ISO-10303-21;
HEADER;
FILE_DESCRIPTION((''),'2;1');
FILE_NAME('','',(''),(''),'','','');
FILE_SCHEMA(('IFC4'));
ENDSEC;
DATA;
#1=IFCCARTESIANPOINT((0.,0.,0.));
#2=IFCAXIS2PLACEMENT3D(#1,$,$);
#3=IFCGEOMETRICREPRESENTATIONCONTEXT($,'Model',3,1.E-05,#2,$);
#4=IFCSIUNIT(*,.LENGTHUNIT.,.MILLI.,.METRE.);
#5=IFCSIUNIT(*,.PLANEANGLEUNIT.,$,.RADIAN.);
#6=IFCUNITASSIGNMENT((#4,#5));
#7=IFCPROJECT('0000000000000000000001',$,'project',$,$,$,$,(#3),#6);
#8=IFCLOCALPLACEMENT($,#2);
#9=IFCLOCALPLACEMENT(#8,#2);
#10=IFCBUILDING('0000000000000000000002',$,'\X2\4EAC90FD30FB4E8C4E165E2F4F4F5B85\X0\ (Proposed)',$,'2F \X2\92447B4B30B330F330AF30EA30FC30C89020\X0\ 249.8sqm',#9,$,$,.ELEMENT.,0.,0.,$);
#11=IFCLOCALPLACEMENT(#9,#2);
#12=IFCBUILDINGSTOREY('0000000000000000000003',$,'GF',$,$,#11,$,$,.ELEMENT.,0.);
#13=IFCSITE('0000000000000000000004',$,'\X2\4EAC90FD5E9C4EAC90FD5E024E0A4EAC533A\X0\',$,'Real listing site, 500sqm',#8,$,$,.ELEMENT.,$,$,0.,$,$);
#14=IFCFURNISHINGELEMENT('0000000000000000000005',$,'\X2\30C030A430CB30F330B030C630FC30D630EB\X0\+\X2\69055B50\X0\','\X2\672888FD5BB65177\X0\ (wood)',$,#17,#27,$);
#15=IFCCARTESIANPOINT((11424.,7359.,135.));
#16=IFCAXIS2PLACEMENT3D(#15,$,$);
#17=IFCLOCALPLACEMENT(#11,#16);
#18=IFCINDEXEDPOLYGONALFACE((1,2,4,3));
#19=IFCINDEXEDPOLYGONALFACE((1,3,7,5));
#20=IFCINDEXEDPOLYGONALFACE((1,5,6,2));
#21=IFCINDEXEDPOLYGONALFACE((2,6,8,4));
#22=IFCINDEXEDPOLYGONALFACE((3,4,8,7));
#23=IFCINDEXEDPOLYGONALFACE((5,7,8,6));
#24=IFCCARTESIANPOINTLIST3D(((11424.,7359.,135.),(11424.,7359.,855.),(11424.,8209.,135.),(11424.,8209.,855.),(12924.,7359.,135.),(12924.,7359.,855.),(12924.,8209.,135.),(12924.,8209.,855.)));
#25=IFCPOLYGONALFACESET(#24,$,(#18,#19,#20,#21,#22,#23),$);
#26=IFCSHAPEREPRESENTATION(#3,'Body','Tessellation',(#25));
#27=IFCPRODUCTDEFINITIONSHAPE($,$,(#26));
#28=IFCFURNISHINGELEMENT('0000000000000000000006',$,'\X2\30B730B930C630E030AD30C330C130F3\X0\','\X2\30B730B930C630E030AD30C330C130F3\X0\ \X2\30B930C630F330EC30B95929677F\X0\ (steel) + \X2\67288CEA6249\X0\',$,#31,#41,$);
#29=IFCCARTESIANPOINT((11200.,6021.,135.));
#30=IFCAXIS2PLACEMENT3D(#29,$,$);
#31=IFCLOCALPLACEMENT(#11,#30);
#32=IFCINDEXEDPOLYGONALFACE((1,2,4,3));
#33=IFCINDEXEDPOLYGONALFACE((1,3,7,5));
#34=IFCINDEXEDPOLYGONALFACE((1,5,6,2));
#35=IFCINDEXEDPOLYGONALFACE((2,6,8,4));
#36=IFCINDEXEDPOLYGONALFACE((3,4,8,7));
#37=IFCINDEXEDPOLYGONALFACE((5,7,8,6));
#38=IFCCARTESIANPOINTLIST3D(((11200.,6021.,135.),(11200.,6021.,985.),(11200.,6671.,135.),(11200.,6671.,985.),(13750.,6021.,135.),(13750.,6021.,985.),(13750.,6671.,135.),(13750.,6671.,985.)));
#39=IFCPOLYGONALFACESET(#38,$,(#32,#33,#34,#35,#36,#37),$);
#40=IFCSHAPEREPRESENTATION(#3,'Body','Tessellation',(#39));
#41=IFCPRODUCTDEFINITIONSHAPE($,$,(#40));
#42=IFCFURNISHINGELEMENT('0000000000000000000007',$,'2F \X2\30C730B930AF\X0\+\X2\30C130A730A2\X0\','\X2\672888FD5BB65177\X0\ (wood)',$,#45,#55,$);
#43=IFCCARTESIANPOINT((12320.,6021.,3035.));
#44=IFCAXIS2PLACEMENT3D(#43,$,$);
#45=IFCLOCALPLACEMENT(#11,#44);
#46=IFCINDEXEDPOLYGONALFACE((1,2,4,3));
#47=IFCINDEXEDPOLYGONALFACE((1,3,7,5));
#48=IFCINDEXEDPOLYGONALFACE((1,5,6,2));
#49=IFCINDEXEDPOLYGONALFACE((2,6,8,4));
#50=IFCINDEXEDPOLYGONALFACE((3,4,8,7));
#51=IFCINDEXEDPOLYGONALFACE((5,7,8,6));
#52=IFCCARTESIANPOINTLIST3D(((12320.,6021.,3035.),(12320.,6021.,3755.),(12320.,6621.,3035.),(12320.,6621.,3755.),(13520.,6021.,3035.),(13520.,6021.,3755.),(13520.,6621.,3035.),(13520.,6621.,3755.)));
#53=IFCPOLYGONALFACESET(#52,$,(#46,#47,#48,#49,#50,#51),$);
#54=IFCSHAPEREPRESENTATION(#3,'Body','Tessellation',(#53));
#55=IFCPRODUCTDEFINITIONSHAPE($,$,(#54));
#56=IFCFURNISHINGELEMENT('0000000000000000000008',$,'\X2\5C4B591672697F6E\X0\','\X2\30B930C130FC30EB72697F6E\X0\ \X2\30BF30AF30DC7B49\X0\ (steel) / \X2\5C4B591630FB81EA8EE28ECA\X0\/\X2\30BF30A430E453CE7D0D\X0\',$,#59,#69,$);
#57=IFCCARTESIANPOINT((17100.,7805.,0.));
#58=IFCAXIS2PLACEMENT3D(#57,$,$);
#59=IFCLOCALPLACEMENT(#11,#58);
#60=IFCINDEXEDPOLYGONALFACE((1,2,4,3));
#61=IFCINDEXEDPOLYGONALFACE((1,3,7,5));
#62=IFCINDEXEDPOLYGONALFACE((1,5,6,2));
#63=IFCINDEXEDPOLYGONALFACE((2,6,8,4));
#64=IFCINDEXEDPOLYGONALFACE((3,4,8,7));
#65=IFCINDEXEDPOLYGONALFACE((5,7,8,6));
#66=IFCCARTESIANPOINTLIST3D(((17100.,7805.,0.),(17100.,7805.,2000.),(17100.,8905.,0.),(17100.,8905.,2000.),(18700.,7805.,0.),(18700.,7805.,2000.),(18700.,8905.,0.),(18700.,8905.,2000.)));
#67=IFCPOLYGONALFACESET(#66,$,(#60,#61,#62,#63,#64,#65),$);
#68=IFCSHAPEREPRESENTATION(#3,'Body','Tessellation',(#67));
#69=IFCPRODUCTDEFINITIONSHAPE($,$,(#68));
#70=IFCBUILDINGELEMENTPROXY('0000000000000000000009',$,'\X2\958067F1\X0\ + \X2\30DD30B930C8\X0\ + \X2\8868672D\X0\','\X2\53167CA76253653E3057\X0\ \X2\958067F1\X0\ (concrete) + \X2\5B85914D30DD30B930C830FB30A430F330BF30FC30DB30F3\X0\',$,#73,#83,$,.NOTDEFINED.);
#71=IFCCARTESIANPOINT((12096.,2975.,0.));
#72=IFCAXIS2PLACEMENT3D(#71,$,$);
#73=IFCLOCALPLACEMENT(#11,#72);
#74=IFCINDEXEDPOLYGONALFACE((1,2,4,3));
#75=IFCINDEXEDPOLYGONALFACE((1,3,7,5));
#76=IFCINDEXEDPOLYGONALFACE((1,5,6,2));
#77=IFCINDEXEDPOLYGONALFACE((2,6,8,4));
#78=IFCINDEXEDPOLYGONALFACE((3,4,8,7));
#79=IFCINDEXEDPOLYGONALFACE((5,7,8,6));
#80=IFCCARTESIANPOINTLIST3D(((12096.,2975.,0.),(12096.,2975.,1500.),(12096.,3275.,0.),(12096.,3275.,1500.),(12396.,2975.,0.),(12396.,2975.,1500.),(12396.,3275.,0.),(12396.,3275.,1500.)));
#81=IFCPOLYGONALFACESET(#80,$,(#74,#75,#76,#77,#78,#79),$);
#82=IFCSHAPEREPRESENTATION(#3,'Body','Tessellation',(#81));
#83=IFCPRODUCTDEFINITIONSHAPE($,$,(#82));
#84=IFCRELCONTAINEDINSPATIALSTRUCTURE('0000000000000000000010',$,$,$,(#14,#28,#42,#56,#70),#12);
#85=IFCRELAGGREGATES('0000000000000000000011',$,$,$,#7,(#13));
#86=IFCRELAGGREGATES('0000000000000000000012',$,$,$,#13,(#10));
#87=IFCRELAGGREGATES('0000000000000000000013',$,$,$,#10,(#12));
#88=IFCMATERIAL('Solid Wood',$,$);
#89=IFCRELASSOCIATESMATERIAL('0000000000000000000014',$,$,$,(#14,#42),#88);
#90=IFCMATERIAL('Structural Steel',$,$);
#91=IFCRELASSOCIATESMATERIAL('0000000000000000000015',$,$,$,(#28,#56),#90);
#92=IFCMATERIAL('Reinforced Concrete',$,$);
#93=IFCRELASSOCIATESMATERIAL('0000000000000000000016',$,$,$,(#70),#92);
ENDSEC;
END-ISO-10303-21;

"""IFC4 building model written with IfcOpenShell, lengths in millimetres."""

from ifc_helpers import new_model, si_unit, frame, frame_2d, origin, place, context, project, spatial, rectangle, extrude, material, element, save


model = new_model("IFC4")

# Units and contexts
model_context = context("Model", 3, precision=1e-05, world=origin())
ifc_project = project(units=[si_unit("LENGTHUNIT", "METRE", prefix="MILLI"), si_unit("PLANEANGLEUNIT", "RADIAN")], contexts=[model_context])

# Site, building, storey
site_placement = place(None, origin())
site = spatial("IfcSite", under=ifc_project, at=site_placement, Name="京都府京都市上京区", ObjectType="Real listing site, 500sqm", CompositionType="ELEMENT", RefElevation=0.0)
building_placement = place(site_placement, origin())
building = spatial("IfcBuilding", under=site, at=building_placement, Name="京都・二世帯住宅 (Proposed)", ObjectType="2F 鉄筋コンクリート造 249.8sqm", CompositionType="ELEMENT", ElevationOfRefHeight=0.0, ElevationOfTerrain=0.0)
storey_placement = place(building_placement, origin())
storey = spatial("IfcBuildingStorey", under=building, at=storey_placement, Name="GF", CompositionType="ELEMENT", Elevation=0.0)

# Shared definitions
ifc_material_1 = material(Name="Solid Wood")

# Shared definitions
ifc_material_2 = material(Name="Reinforced Concrete")

# Shared definitions
ifc_material_3 = material(Name="Structural Steel")

# Furnishing elements
furnishing_1_placement = place(storey_placement, frame((11424.0, 7359.0, 135.0)))
element("IfcFurnishingElement", 1, at=furnishing_1_placement, inside=storey, material=ifc_material_1, Name="ダイニングテーブル+椅子", Description="木製家具 (wood)", context=model_context, shape_type="SweptSolid", body=[
    extrude(rectangle(XDim=1500.0, YDim=850.0, at=frame_2d((750.0, 425.0))), frame((11424.0, 7359.0, 135.0)), (0.0, 0.0, 1.0), 720.0),
])
furnishing_2_placement = place(storey_placement, frame((11200.0, 6021.0, 135.0)))
element("IfcFurnishingElement", 2, at=furnishing_2_placement, inside=storey, material=ifc_material_3, Name="システムキッチン", Description="システムキッチン ステンレス天板 (steel) + 木質扉", context=model_context, shape_type="SweptSolid", body=[
    extrude(rectangle(XDim=2550.0, YDim=650.0, at=frame_2d((1275.0, 325.0))), frame((11200.0, 6021.0, 135.0)), (0.0, 0.0, 1.0), 850.0),
])
furnishing_3_placement = place(storey_placement, frame((12320.0, 6021.0, 3035.0)))
element("IfcFurnishingElement", 3, at=furnishing_3_placement, inside=storey, material=ifc_material_1, Name="2F デスク+チェア", Description="木製家具 (wood)", context=model_context, shape_type="SweptSolid", body=[
    extrude(rectangle(XDim=1200.0, YDim=600.0, at=frame_2d((600.0, 300.0))), frame((12320.0, 6021.0, 3035.0)), (0.0, 0.0, 1.0), 720.0),
])
furnishing_4_placement = place(storey_placement, frame((17100.0, 7805.0, 0.0)))
element("IfcFurnishingElement", 4, at=furnishing_4_placement, inside=storey, material=ifc_material_3, Name="屋外物置", Description="スチール物置 タクボ等 (steel) / 屋外・自転車/タイヤ収納", context=model_context, shape_type="SweptSolid", body=[
    extrude(rectangle(XDim=1600.0, YDim=1100.0, at=frame_2d((800.0, 550.0))), frame((17100.0, 7805.0, 0.0)), (0.0, 0.0, 1.0), 2000.0),
])

# Building element proxy
proxy_placement = place(storey_placement, frame((12096.0, 2975.0, 0.0)))
element("IfcBuildingElementProxy", 5, at=proxy_placement, inside=storey, material=ifc_material_2, Name="門柱 + ポスト + 表札", Description="化粧打放し 門柱 (concrete) + 宅配ポスト・インターホン", PredefinedType="NOTDEFINED", context=model_context, shape_type="SweptSolid", body=[
    extrude(rectangle(XDim=300.0, YDim=300.0, at=frame_2d((150.0, 150.0))), frame((12096.0, 2975.0, 0.0)), (0.0, 0.0, 1.0), 1500.0),
])

save(model, "model.ifc")
